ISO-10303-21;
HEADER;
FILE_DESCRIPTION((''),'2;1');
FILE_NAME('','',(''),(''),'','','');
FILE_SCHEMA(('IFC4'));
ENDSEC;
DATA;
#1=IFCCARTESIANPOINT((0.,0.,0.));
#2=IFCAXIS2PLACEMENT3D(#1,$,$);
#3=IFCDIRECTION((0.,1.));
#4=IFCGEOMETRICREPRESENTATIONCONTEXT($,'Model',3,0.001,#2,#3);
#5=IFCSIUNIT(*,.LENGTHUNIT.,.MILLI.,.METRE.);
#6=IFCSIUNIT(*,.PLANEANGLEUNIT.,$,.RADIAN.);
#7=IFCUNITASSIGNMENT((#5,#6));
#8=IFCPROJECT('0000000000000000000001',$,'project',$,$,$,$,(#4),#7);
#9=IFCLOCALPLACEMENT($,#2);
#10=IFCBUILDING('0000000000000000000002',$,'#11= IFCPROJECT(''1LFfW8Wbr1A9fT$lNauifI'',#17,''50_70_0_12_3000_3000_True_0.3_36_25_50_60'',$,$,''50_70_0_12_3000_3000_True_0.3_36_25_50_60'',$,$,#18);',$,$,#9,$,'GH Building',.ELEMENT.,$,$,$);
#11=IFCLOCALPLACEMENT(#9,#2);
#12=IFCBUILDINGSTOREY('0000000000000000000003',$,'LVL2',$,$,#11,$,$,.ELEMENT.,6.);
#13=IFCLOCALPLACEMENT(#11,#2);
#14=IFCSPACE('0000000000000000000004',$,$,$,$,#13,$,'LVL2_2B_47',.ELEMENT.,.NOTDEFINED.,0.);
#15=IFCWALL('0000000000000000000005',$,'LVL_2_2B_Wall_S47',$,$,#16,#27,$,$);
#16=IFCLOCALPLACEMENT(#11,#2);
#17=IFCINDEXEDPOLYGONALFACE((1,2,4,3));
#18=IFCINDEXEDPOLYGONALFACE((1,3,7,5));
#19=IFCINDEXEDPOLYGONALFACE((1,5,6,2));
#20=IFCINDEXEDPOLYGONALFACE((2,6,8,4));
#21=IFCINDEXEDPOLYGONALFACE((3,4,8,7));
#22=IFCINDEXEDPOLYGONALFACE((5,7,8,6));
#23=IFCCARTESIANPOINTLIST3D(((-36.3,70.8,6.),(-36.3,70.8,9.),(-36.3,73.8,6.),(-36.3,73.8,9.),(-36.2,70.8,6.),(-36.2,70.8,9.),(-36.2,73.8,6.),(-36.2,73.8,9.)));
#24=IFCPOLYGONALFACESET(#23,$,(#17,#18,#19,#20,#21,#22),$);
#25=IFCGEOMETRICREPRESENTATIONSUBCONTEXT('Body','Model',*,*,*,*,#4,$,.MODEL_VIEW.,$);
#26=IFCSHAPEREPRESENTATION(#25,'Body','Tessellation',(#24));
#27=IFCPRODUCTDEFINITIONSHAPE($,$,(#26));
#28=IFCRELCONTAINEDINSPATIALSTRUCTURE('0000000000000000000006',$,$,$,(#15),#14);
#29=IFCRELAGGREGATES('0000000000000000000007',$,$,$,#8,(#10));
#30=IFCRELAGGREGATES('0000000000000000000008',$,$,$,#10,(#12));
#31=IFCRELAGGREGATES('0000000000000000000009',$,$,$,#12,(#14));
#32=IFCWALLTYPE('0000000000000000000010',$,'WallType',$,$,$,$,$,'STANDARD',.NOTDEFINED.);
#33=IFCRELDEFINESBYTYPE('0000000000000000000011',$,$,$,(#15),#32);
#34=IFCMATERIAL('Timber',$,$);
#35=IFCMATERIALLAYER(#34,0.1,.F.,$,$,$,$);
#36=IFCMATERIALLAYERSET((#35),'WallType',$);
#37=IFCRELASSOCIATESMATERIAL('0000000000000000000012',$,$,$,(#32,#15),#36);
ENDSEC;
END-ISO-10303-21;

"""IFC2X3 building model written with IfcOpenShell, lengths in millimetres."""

from ifc_helpers import new_model, si_unit, direction, frame, frame_2d, origin, place, context, subcontext, project, spatial, rectangle, extrude, material, layer, layer_set, layer_usage, type_object, element, save


model = new_model("IFC2X3")

# Units and contexts
model_context = context("Model", 3, precision=0.001, world=origin(), true_north=direction((0.0, 1.0)))
body_context = subcontext(model_context, "Body", "Model", "MODEL_VIEW")
ifc_project = project(units=[si_unit("LENGTHUNIT", "METRE", prefix="MILLI"), si_unit("PLANEANGLEUNIT", "RADIAN")], contexts=[model_context])

# Building, storey, space
building_placement = place(None, origin())
building = spatial("IfcBuilding", under=ifc_project, at=building_placement, Name="#11= IFCPROJECT('1LFfW8Wbr1A9fT$lNauifI',#17,'50_70_0_12_3000_3000_True_0.3_36_25_50_60',$,$,'50_70_0_12_3000_3000_True_0.3_36_25_50_60',$,$,#18);", LongName="GH Building", CompositionType="ELEMENT")
storey_placement = place(building_placement, origin())
storey = spatial("IfcBuildingStorey", under=building, at=storey_placement, Name="LVL2", CompositionType="ELEMENT", Elevation=6.0)
space_1_placement = place(storey_placement, origin())
space_1 = spatial("IfcSpace", under=storey, at=space_1_placement, LongName="LVL2_2B_47", CompositionType="ELEMENT", InteriorOrExteriorSpace="NOTDEFINED", ElevationWithFlooring=0.0)

# Wall
ifc_material_1 = material(Name="Timber")
ifc_layer_1 = layer(ifc_material_1, 0.1, ventilated=False)
ifc_layer_set_1 = layer_set([ifc_layer_1], Name="WallType")
ifc_layer_usage_1 = layer_usage(ifc_layer_set_1, "AXIS2", "NEGATIVE", 0.0)
wall_type_1 = type_object("IfcWallType", Name="WallType", ElementType="STANDARD", PredefinedType="NOTDEFINED", material=ifc_layer_set_1)
wall_1_placement = place(space_1_placement, frame((-36.2, 73.8, 6.0), z_axis=(0.0, 0.0, 1.0), x_axis=(0.0, -1.0, 0.0)))
element("IfcWall", 1, at=wall_1_placement, inside=space_1, type_object=wall_type_1, material=ifc_layer_usage_1, Name="LVL_2_2B_Wall_S47", context=body_context, shape_type="SweptSolid", body=[
    extrude(rectangle(XDim=3.0, YDim=0.1, at=frame_2d((1.5, -0.1))), origin(), (0.0, 0.0, 1.0), 3.0),
])

save(model, "model.ifc")
